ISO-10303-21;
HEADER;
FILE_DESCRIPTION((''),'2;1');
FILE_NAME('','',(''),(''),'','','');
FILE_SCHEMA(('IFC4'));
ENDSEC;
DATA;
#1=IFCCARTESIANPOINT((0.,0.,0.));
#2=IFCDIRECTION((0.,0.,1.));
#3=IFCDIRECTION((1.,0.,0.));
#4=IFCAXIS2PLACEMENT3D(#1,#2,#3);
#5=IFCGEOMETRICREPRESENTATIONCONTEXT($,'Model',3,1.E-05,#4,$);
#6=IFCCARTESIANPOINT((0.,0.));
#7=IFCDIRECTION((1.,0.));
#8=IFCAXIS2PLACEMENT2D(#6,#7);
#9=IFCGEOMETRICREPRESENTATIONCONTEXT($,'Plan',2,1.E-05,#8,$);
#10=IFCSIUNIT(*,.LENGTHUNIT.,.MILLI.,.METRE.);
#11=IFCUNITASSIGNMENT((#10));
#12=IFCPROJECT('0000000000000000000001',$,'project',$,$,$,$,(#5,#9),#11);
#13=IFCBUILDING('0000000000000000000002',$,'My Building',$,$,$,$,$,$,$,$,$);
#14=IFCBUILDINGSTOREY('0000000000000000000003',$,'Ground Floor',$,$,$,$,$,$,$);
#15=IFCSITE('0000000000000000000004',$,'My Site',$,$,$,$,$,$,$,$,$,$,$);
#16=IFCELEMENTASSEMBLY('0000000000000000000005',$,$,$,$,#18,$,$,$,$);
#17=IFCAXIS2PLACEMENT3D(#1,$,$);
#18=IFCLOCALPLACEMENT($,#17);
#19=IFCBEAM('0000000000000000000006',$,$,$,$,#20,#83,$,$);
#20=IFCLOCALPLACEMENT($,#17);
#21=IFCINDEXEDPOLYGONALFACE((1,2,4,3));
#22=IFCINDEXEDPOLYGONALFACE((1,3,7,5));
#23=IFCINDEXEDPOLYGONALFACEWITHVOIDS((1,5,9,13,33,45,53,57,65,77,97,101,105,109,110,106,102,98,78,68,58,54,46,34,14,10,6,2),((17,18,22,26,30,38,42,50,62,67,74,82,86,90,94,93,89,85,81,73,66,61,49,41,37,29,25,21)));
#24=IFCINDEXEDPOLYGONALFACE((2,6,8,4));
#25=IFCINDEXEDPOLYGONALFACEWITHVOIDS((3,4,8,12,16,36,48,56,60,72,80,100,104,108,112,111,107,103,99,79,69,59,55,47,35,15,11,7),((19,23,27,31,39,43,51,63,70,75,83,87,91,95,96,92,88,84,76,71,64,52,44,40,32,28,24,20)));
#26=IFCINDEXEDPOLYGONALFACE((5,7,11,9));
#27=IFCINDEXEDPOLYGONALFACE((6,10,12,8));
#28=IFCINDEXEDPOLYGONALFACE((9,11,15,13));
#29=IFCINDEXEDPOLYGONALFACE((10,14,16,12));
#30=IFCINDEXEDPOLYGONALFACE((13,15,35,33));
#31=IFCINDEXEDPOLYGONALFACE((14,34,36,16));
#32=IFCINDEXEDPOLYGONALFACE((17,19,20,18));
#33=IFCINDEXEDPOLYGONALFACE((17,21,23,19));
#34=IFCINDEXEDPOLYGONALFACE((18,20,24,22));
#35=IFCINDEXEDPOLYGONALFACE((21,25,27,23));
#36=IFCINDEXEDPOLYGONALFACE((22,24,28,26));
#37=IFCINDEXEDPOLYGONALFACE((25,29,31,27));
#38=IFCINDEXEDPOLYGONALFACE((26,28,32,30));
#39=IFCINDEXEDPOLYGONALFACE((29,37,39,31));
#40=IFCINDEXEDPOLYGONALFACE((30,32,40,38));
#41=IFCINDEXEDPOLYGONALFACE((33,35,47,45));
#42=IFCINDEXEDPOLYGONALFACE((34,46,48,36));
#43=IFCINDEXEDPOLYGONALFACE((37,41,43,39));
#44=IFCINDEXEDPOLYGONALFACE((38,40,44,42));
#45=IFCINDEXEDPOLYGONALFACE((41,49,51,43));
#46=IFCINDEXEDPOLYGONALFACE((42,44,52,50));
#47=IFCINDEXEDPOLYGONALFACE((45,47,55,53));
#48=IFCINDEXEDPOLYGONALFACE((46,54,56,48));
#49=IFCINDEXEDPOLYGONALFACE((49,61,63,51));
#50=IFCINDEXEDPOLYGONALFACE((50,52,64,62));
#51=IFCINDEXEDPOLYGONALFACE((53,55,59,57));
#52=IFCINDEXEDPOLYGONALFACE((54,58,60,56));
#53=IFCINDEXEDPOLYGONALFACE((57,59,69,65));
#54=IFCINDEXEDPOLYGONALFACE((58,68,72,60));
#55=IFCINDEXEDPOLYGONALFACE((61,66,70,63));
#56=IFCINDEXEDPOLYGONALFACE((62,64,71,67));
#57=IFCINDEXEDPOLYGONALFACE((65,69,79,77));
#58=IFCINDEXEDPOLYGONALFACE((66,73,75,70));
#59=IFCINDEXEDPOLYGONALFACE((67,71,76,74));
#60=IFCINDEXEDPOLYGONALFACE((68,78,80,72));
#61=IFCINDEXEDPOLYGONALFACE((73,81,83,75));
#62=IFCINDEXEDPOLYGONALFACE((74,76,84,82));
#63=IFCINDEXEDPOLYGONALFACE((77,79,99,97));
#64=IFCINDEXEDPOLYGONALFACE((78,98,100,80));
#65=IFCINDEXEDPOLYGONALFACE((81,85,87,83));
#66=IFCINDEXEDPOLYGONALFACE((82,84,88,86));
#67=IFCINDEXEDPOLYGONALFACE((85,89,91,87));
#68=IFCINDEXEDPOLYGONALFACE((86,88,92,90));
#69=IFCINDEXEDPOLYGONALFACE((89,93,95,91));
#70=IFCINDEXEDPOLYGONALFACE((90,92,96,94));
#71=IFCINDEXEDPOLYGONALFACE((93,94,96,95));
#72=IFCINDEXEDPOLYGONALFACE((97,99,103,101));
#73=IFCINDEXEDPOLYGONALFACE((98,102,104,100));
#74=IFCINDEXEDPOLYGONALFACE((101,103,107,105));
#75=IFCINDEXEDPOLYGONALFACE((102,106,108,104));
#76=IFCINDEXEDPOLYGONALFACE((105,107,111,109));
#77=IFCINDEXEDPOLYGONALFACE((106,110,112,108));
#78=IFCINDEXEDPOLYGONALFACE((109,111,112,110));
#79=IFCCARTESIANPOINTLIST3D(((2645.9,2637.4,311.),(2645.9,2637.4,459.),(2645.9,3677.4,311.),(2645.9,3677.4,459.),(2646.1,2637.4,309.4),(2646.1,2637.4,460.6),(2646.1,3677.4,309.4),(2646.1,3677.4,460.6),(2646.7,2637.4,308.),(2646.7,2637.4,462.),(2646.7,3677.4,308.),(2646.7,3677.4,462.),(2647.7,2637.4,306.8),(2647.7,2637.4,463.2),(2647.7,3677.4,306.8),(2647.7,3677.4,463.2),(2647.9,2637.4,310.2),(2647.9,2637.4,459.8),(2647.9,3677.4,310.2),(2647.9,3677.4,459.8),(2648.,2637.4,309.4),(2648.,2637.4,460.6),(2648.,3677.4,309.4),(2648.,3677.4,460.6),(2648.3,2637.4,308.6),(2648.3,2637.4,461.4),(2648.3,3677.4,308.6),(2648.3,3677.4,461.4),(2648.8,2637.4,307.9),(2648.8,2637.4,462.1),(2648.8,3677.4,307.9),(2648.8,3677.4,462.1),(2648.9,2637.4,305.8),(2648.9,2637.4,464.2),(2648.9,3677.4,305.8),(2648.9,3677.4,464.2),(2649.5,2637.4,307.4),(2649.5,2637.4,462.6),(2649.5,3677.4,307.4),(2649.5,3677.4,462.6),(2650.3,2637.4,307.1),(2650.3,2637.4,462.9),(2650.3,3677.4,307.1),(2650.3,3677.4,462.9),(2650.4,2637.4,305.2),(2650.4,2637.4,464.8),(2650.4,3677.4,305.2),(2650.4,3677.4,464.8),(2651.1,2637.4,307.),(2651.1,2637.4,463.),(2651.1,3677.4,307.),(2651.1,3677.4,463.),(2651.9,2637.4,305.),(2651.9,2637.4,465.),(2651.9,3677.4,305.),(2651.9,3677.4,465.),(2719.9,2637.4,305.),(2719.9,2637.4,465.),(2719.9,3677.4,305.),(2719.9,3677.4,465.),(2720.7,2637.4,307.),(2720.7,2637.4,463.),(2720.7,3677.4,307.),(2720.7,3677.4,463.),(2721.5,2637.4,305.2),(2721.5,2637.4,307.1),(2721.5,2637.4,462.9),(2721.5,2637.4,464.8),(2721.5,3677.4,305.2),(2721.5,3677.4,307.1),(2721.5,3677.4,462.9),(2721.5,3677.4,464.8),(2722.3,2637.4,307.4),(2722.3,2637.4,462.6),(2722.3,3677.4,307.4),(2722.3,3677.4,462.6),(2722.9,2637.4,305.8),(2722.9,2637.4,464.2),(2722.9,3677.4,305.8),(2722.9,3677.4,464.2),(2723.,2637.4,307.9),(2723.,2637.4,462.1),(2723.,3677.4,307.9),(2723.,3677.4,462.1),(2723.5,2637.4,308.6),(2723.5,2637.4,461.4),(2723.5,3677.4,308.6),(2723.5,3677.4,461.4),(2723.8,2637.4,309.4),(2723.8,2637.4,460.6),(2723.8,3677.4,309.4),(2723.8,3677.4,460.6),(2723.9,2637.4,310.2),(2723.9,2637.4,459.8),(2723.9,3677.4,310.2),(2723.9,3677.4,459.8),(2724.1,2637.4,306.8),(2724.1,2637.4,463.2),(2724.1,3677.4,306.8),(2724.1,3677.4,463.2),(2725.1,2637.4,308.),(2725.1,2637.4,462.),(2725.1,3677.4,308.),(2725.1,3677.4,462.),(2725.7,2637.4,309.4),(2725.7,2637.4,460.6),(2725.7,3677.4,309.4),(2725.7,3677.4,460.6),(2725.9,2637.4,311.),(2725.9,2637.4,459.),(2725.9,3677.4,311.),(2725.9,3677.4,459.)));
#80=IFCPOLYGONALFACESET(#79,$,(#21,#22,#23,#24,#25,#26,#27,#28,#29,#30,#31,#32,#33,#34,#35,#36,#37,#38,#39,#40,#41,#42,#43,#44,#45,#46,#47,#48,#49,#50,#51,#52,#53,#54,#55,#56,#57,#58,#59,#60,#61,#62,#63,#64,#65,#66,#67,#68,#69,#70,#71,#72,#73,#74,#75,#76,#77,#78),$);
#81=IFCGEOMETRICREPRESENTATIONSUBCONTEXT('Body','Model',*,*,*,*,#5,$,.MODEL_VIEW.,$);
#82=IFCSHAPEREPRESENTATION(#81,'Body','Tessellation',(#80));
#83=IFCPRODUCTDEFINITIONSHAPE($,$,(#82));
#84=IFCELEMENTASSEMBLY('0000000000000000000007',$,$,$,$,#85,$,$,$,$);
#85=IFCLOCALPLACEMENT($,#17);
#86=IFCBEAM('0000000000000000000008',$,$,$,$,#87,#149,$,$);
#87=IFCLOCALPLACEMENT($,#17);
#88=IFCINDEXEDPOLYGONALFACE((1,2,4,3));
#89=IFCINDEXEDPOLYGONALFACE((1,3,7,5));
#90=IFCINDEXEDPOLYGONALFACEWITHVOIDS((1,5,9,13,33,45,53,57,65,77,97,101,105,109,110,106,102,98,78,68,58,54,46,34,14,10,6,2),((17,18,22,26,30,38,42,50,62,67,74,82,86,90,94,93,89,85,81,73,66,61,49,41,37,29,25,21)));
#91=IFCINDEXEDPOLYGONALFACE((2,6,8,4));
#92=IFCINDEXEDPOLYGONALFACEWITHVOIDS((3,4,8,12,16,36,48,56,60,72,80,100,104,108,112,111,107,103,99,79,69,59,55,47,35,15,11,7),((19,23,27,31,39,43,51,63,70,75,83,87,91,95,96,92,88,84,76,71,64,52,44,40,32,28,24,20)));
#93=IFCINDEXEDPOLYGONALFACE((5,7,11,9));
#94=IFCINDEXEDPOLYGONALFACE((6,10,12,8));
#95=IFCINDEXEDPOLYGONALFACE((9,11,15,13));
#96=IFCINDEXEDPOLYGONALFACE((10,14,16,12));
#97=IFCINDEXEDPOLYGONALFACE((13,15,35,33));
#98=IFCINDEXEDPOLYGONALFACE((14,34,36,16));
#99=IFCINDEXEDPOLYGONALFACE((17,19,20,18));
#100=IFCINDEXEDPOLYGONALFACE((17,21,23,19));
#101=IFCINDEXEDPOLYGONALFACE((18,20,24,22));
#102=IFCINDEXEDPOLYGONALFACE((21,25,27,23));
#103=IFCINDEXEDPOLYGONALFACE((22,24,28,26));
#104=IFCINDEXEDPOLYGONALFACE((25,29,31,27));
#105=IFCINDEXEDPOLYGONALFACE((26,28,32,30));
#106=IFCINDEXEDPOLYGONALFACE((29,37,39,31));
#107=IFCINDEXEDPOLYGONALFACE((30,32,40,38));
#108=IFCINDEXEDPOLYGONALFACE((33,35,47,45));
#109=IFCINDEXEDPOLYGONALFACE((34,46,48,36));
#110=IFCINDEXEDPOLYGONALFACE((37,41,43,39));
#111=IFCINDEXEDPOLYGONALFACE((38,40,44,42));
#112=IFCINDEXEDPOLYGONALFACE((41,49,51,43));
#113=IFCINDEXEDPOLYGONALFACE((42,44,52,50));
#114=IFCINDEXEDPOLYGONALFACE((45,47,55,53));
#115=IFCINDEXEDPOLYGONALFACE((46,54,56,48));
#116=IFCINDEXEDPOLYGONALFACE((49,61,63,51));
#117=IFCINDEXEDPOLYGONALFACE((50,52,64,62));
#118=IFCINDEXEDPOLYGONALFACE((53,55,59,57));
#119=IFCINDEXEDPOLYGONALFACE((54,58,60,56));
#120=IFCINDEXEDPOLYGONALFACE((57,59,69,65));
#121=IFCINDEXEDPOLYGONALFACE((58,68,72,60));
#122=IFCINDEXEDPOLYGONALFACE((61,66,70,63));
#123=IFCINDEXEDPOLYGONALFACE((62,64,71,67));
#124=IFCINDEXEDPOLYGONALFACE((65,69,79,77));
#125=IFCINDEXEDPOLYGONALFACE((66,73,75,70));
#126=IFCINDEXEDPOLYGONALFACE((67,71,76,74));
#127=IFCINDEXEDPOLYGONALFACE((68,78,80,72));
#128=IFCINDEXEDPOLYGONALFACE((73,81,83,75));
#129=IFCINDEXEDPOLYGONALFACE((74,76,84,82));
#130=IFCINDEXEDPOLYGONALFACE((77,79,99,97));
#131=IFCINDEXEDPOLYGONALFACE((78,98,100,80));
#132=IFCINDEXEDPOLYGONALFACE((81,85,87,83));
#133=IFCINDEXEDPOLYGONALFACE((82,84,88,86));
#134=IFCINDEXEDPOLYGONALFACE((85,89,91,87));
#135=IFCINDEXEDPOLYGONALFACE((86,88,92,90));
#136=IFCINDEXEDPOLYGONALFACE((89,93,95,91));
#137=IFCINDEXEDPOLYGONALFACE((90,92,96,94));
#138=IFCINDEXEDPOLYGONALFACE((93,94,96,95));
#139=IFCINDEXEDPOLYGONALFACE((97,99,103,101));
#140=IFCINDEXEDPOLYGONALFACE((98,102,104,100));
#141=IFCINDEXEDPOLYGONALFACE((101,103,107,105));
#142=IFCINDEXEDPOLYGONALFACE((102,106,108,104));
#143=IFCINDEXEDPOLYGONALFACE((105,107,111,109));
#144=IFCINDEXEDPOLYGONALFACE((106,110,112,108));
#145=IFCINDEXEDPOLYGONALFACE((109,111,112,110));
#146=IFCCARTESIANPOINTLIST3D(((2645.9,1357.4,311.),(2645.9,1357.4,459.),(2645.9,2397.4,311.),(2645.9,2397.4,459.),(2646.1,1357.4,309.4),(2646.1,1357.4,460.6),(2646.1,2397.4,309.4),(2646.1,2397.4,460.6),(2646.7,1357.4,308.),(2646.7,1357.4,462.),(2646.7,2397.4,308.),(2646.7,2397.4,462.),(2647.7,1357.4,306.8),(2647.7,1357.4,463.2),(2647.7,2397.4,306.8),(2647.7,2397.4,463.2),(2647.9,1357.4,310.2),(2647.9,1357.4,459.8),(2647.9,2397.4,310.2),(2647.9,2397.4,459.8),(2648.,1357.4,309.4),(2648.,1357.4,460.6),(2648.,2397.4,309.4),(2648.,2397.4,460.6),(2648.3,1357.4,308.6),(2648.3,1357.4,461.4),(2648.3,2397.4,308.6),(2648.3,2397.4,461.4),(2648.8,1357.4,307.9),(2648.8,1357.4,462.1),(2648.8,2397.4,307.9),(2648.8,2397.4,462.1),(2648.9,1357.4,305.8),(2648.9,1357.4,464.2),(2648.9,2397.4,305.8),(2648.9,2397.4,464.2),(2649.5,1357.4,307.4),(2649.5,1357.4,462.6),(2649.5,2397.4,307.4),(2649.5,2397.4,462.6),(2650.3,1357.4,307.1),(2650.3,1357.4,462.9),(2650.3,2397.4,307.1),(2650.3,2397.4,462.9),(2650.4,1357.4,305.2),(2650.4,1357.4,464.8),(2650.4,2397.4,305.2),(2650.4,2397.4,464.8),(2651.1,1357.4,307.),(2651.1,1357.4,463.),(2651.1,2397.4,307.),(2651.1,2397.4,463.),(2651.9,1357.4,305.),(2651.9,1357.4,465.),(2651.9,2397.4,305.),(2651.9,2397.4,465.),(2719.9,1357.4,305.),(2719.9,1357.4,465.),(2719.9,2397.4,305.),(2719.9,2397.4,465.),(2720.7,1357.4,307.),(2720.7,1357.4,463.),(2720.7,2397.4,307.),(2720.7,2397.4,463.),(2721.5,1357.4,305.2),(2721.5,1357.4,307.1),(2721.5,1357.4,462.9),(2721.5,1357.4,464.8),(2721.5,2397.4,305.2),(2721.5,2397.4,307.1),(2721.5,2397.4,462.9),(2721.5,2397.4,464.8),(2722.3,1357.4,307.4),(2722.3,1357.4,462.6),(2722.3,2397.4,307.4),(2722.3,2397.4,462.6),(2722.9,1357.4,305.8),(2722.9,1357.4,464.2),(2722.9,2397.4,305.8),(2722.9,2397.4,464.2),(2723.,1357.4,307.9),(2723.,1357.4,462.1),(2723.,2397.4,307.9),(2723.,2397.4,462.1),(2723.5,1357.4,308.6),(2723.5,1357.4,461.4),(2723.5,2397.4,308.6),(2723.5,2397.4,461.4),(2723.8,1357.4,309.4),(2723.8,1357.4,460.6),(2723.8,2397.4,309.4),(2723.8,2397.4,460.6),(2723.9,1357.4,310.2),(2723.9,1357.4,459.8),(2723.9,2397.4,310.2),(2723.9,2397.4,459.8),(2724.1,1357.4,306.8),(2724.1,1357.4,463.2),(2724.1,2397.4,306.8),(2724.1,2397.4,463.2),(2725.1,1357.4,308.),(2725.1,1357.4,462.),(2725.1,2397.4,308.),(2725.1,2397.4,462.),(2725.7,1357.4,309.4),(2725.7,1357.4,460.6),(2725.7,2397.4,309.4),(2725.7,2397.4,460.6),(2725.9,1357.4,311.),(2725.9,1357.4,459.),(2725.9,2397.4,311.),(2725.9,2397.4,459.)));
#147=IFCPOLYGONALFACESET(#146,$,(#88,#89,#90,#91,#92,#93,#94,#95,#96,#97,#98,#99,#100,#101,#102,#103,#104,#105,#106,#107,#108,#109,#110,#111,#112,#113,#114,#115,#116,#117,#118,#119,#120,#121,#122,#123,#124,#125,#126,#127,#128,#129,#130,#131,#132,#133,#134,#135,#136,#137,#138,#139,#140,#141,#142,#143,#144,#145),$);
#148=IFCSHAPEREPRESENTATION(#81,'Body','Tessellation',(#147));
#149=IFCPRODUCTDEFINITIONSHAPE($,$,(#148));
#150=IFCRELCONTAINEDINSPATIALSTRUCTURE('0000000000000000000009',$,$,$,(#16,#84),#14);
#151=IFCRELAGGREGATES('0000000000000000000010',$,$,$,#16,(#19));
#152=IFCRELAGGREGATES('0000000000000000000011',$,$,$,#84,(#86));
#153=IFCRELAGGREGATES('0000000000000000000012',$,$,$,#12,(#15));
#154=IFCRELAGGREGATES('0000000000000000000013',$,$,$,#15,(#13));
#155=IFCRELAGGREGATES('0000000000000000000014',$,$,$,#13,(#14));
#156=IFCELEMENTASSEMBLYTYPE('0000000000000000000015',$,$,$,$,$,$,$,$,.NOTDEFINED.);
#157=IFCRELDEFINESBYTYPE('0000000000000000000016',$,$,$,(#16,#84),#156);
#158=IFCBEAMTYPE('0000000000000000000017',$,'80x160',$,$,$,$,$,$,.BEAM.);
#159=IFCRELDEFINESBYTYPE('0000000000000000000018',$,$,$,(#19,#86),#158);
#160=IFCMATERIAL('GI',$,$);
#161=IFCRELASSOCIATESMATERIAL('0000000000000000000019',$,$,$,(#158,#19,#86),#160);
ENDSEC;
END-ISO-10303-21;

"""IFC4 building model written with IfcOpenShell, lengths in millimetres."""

from ifc_helpers import new_model, si_unit, frame, origin_with_axes, origin_2d_with_axis, place, context, subcontext, project, spatial, hollow_rectangle, extrude, material, material_profile, profile_set, profile_usage, type_object, element, aggregate, save


model = new_model("IFC4")

# Units and contexts
model_context = context("Model", 3, precision=1e-05, world=origin_with_axes())
plan_context = context("Plan", 2, precision=1e-05, world=origin_2d_with_axis())
body_context = subcontext(model_context, "Body", "Model", "MODEL_VIEW")
ifc_project = project(units=[si_unit("LENGTHUNIT", "METRE", prefix="MILLI")], contexts=[model_context, plan_context])

# Site, building, storey
site = spatial("IfcSite", under=ifc_project, Name="My Site")
building = spatial("IfcBuilding", under=site, Name="My Building")
storey = spatial("IfcBuildingStorey", under=building, Name="Ground Floor")

# Shared definitions
ifc_material = material(Name="GI")

# Element assemblies, beams
element_assembly_type_1 = type_object("IfcElementAssemblyType", PredefinedType="NOTDEFINED")
ifc_material_profile_1 = material_profile(ifc_material, hollow_rectangle(XDim=80.0, YDim=160.0, WallThickness=2.0, InnerFilletRadius=3.2, OuterFilletRadius=6.0))
ifc_profile_set_1 = profile_set([ifc_material_profile_1], Name="80x160 GI Rectangular Hollow")
beam_type = type_object("IfcBeamType", Name="80x160", PredefinedType="BEAM", material=ifc_profile_set_1)
assembly_1_placement = place(None, frame((2685.9, 2557.4, 385.0), z_axis=(0.0, 1.0, 0.0), x_axis=(1.0, 0.0, 0.0)))
assembly_1 = element("IfcElementAssembly", 1, at=assembly_1_placement, inside=storey, type_object=element_assembly_type_1)
ifc_profile_usage_1 = profile_usage(ifc_profile_set_1)
beam_1_placement = place(assembly_1_placement, frame((0.0, 0.0, 80.0), z_axis=(0.0, 0.0, 1.0), x_axis=(1.0, 0.0, 0.0)))
beam_1 = element("IfcBeam", 2, at=beam_1_placement, type_object=beam_type, material=ifc_profile_usage_1, context=body_context, shape_type="SweptSolid", body=[
    extrude(hollow_rectangle(XDim=80.0, YDim=160.0, WallThickness=2.0, InnerFilletRadius=3.2, OuterFilletRadius=6.0), origin_with_axes(), (0.0, 0.0, 1.0), 1040.0),
])
aggregate(assembly_1, [beam_1])
assembly_2_placement = place(None, frame((2685.9, 1277.4, 385.0), z_axis=(0.0, 1.0, 0.0), x_axis=(1.0, 0.0, 0.0)))
assembly_2 = element("IfcElementAssembly", 3, at=assembly_2_placement, inside=storey, type_object=element_assembly_type_1)
ifc_profile_usage_2 = profile_usage(ifc_profile_set_1)
beam_2_placement = place(assembly_2_placement, frame((0.0, 0.0, 80.0), z_axis=(0.0, 0.0, 1.0), x_axis=(1.0, 0.0, 0.0)))
beam_2 = element("IfcBeam", 4, at=beam_2_placement, type_object=beam_type, material=ifc_profile_usage_2, context=body_context, shape_type="SweptSolid", body=[
    extrude(hollow_rectangle(XDim=80.0, YDim=160.0, WallThickness=2.0, InnerFilletRadius=3.2, OuterFilletRadius=6.0), origin_with_axes(), (0.0, 0.0, 1.0), 1040.0),
])
aggregate(assembly_2, [beam_2])

save(model, "model.ifc")
